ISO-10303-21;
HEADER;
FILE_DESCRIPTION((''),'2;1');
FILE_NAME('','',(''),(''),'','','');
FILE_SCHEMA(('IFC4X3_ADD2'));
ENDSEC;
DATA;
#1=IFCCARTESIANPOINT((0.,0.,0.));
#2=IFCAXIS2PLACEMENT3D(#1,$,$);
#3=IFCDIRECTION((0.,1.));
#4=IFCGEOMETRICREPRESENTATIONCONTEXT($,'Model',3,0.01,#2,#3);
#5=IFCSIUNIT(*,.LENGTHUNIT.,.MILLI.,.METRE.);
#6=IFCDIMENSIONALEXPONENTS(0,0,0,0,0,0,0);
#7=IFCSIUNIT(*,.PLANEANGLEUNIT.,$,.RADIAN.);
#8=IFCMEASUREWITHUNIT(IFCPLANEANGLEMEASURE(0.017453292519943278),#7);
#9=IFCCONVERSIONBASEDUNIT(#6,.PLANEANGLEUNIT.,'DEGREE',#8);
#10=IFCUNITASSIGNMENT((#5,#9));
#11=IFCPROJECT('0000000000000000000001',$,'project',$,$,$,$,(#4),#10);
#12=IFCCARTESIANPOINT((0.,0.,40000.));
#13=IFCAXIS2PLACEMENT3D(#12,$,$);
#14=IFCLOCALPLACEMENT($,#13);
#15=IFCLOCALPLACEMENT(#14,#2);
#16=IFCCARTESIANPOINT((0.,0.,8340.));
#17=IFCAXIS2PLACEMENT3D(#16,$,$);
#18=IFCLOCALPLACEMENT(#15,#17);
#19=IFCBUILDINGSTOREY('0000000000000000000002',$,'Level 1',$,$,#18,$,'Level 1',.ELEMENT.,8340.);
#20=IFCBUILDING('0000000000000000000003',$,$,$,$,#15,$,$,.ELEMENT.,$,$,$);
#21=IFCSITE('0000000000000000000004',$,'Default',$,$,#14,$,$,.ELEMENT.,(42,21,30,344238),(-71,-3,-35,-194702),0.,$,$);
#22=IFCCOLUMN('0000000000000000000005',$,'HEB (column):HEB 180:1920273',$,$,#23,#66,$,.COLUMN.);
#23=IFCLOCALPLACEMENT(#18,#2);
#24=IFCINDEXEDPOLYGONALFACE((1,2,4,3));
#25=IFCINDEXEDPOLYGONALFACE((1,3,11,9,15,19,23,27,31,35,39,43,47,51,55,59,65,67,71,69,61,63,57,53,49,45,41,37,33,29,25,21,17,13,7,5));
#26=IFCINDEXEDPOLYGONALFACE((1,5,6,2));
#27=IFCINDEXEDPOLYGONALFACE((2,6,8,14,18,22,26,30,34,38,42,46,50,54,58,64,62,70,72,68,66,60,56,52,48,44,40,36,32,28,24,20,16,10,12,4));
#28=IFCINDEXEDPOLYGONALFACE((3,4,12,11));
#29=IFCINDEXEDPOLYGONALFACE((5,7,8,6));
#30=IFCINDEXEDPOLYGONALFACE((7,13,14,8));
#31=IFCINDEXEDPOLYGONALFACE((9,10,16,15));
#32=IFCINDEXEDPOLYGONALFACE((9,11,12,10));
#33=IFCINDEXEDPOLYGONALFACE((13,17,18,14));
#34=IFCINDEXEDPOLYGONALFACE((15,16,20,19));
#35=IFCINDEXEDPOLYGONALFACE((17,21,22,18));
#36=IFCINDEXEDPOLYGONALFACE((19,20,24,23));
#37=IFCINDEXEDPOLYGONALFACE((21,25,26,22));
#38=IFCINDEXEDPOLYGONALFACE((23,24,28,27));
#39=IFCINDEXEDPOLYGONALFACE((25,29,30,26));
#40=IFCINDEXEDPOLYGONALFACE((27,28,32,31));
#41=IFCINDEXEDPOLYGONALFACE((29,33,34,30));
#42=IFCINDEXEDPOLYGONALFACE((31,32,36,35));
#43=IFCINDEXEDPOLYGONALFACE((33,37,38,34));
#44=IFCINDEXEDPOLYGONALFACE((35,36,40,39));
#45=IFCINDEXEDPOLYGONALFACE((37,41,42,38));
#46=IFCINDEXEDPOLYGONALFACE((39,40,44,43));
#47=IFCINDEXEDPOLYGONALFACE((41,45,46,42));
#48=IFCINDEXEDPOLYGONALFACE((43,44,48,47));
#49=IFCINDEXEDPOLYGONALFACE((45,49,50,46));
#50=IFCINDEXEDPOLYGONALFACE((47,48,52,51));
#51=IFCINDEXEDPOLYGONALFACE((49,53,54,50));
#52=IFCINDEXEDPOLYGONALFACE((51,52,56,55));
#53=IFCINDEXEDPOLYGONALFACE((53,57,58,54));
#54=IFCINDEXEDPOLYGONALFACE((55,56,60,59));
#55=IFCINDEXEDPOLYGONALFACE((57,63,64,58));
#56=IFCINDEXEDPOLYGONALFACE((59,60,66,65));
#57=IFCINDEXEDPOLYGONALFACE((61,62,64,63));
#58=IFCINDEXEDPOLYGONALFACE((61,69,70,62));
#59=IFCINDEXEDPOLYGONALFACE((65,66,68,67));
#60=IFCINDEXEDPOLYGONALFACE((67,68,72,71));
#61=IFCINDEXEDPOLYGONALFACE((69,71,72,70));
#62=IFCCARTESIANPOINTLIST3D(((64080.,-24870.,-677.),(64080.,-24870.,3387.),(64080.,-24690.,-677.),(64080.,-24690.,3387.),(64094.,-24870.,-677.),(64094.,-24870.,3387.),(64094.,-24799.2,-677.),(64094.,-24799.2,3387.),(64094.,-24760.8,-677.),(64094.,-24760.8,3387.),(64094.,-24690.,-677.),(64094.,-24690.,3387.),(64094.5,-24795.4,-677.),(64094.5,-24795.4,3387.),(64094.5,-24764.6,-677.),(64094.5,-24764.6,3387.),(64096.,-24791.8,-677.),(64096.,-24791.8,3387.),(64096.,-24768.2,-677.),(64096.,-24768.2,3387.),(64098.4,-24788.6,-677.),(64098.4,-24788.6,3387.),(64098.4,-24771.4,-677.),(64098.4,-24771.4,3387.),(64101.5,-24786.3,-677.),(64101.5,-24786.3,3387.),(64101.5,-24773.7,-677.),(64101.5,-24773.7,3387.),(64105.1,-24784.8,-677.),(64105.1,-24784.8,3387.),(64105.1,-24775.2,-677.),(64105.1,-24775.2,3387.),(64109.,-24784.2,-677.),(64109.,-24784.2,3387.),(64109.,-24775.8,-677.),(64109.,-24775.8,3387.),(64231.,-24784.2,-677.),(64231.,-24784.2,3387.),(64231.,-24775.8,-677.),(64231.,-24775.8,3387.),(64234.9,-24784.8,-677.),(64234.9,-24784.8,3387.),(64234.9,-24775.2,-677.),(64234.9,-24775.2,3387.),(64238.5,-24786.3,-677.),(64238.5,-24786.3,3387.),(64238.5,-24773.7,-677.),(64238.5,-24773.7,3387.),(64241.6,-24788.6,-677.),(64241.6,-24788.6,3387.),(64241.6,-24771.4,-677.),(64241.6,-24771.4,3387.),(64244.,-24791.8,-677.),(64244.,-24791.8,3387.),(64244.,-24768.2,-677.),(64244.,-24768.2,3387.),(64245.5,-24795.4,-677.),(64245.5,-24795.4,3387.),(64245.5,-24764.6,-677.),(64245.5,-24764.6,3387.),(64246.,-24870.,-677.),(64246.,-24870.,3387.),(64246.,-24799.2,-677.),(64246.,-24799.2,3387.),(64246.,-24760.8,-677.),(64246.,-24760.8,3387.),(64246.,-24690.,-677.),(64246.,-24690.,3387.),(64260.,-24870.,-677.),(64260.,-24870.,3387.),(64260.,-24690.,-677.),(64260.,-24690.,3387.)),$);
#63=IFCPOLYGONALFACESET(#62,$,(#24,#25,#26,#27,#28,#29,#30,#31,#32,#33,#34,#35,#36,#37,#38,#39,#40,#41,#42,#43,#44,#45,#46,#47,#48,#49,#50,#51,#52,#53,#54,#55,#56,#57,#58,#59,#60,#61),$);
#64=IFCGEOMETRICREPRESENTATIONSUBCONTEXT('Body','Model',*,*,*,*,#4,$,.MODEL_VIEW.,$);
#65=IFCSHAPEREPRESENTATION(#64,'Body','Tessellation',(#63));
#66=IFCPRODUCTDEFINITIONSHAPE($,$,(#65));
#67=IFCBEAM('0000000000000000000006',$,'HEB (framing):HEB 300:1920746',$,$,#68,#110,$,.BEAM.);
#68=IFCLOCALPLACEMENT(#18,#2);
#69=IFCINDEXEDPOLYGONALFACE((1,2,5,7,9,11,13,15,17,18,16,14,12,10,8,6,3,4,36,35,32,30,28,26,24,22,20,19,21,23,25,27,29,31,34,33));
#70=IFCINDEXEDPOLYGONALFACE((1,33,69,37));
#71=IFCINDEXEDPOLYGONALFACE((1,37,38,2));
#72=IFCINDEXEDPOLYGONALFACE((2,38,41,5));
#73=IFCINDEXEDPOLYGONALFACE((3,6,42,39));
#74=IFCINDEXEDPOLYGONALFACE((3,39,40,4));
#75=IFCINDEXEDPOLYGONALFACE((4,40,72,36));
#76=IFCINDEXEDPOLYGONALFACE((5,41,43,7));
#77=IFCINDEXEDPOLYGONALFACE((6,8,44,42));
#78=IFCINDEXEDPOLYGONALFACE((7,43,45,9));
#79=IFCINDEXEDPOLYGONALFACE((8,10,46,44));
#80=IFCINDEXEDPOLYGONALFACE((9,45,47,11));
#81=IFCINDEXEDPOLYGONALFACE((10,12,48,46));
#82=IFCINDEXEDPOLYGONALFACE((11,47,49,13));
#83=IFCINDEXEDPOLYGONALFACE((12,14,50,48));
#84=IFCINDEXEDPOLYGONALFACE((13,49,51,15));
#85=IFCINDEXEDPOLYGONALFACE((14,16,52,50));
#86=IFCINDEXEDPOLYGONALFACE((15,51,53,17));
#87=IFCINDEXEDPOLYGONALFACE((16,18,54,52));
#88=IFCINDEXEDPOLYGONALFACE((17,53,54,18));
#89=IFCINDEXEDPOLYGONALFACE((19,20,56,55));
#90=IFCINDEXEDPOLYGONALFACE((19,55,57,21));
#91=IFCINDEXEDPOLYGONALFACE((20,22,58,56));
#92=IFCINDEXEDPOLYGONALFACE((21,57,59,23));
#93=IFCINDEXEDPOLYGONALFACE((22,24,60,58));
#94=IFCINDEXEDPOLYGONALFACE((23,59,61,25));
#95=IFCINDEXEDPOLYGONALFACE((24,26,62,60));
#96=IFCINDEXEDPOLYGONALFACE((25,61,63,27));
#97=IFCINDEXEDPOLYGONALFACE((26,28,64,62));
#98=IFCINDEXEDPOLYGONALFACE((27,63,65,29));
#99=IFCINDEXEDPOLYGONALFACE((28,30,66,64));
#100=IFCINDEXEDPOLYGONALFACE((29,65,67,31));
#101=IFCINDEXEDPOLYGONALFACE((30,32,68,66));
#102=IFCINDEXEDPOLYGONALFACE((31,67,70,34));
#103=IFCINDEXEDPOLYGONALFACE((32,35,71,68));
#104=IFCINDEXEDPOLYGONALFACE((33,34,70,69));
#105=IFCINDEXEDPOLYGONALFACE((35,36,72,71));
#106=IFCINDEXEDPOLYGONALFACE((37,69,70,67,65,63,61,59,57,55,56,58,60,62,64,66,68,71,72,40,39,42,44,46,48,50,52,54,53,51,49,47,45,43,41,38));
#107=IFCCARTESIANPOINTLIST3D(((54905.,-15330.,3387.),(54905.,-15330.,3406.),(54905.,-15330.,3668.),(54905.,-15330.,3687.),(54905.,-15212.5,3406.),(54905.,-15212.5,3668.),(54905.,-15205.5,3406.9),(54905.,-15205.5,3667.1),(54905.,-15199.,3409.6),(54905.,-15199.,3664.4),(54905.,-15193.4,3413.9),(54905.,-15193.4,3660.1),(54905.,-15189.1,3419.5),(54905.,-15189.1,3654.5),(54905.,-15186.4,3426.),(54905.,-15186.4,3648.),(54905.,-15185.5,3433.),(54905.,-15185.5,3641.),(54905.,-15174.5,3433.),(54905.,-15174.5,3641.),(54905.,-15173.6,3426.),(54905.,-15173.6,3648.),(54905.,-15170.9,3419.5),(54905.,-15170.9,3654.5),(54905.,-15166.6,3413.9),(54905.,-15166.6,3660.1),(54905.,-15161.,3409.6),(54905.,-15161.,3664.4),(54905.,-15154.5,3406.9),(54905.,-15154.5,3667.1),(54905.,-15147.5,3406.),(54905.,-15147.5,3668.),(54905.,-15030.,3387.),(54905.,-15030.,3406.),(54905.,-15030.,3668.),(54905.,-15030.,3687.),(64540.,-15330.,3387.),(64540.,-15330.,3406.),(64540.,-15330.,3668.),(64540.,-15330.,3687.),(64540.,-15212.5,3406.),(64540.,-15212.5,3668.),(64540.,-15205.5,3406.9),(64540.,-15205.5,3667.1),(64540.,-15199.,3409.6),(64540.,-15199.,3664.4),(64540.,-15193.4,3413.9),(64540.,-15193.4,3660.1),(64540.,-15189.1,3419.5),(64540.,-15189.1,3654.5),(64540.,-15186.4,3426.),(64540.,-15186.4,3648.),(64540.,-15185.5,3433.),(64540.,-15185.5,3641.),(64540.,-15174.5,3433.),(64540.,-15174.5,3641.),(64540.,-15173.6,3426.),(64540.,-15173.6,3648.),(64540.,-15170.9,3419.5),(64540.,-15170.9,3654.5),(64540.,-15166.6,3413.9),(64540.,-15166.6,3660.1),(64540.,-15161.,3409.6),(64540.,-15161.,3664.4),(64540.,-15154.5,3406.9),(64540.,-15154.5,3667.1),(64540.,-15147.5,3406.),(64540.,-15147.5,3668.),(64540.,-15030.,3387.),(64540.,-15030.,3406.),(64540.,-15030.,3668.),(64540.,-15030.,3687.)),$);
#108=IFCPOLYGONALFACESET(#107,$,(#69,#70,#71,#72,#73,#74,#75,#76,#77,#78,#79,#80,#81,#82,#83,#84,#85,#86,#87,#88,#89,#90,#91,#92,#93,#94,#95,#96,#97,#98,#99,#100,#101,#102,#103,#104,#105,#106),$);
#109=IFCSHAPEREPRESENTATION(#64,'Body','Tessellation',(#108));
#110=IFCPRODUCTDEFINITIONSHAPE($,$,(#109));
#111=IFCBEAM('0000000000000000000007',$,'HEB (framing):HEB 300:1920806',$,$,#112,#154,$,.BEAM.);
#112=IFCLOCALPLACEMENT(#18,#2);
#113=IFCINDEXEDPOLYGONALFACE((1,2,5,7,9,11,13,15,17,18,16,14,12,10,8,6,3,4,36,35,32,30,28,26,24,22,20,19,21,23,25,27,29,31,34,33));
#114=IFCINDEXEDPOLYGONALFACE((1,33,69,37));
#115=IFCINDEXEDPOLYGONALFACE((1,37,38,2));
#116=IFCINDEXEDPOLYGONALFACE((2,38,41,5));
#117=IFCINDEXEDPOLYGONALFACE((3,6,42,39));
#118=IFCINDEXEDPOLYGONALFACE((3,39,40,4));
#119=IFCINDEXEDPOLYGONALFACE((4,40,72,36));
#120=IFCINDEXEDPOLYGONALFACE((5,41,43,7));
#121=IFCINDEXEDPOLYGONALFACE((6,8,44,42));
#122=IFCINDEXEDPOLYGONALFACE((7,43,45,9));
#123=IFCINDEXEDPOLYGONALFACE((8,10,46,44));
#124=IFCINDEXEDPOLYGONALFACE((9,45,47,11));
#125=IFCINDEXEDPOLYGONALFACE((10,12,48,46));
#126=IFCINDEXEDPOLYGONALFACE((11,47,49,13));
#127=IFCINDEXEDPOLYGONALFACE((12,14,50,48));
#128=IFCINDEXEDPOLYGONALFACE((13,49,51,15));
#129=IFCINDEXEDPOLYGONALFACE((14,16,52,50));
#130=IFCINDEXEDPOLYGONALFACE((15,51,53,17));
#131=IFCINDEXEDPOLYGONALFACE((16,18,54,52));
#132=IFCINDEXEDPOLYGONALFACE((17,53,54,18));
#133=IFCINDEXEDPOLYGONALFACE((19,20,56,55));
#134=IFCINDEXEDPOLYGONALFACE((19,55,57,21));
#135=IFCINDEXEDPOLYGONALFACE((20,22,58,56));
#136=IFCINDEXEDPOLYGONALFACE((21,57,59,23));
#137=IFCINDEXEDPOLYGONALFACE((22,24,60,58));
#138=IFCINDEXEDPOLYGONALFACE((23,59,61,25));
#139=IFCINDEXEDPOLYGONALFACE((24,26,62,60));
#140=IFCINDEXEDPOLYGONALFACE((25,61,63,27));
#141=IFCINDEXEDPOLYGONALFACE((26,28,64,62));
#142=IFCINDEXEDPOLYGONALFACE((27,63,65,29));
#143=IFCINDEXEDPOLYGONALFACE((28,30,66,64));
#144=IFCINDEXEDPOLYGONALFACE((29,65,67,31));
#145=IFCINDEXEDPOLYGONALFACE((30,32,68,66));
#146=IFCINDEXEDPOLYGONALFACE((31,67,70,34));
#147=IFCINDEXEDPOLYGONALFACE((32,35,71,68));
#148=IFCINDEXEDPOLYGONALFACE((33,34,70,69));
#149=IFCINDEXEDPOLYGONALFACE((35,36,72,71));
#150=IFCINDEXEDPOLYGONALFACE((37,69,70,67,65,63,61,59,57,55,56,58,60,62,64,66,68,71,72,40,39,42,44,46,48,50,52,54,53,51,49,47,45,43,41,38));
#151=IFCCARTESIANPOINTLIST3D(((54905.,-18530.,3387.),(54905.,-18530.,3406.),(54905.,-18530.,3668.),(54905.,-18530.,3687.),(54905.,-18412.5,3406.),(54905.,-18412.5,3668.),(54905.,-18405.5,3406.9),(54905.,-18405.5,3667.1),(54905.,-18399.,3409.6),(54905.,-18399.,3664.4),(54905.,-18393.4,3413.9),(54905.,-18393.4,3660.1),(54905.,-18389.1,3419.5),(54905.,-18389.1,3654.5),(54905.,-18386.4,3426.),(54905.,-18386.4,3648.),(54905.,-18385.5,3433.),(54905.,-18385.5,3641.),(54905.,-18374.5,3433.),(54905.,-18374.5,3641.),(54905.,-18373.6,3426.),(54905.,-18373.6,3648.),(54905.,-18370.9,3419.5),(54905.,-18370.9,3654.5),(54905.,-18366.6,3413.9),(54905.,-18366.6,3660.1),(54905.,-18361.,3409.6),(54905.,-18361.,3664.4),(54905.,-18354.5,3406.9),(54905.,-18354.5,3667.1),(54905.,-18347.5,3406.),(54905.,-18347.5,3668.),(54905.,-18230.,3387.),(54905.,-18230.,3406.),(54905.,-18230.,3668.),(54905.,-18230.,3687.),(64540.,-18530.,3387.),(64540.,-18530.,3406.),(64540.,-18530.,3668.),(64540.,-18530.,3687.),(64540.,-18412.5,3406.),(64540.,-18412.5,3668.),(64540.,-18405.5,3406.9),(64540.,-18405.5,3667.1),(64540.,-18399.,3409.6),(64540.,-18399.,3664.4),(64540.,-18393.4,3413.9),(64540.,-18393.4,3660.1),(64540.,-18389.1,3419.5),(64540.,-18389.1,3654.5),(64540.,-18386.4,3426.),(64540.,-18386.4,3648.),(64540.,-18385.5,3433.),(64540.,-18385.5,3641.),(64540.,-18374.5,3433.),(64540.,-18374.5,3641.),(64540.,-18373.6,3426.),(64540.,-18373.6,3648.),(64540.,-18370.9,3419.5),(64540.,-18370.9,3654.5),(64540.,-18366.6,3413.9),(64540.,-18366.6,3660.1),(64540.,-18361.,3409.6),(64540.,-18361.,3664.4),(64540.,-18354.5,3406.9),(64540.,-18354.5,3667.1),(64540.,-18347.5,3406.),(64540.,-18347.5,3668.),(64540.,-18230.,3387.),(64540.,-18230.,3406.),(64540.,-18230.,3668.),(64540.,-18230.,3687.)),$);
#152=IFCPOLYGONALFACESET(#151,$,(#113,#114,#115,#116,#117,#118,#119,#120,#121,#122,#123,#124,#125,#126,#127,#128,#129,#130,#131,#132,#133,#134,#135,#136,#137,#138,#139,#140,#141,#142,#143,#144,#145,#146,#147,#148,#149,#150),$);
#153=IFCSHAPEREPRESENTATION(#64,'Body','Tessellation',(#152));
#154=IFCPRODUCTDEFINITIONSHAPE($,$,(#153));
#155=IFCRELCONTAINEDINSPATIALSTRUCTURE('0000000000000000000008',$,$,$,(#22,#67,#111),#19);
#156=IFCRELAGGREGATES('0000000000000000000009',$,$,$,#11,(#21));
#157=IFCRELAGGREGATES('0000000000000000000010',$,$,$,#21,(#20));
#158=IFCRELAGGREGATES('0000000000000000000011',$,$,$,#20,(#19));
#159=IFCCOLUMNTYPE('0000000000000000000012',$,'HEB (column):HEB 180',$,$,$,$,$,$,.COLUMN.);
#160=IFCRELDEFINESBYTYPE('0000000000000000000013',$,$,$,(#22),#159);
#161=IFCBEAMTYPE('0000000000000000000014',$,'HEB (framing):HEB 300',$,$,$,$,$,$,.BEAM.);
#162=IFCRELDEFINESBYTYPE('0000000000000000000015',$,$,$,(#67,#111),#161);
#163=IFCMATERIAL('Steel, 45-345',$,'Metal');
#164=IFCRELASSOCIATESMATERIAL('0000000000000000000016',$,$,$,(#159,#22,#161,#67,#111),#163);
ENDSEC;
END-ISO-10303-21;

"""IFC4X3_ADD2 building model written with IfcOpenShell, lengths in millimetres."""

from ifc_helpers import new_model, entity, si_unit, converted_unit, direction, frame, frame_2d, origin, origin_2d_with_axis, place, context, subcontext, project, spatial, polyline, circle_curve, parameter, trimmed, segment, composite_curve, i_section, outline, extrude, source, transform, mapped, material, material_profile, profile_set, profile_usage, type_object, type_shapes, element, save


model = new_model("IFC4X3_ADD2")

# Units and contexts
model_context = context("Model", 3, precision=0.01, world=origin(), true_north=direction((0.0, 1.0)))
body_context = subcontext(model_context, "Body", "Model", "MODEL_VIEW")
ifc_project = project(units=[si_unit("LENGTHUNIT", "METRE", prefix="MILLI"), converted_unit("PLANEANGLEUNIT", "DEGREE", entity("IfcPlaneAngleMeasure", 0.017453292519943278), si_unit("PLANEANGLEUNIT", "RADIAN"), dimensions=[0, 0, 0, 0, 0, 0, 0])], contexts=[model_context])

# Site, building, storey
site_placement = place(None, frame((0.0, 0.0, 40000.0)))
site = spatial("IfcSite", under=ifc_project, at=site_placement, Name="Default", CompositionType="ELEMENT", RefLatitude=(42, 21, 30, 344238), RefLongitude=(-71, -3, -35, -194702), RefElevation=0.0)
building_placement = place(site_placement, origin())
building = spatial("IfcBuilding", under=site, at=building_placement, CompositionType="ELEMENT")
storey_placement = place(building_placement, frame((0.0, 0.0, 8340.0)))
storey = spatial("IfcBuildingStorey", under=building, at=storey_placement, Name="Level 1", LongName="Level 1", CompositionType="ELEMENT", Elevation=8340.0)

# Column
ifc_material_1 = material(Name="Steel, 45-345", Category="Metal")
ifc_material_profile_1 = material_profile(ifc_material_1, i_section(OverallWidth=180.0, OverallDepth=180.0, WebThickness=8.5, FlangeThickness=14.0, FilletRadius=15.0, at=origin_2d_with_axis()), Name="HEB 180")
ifc_profile_set_1 = profile_set([ifc_material_profile_1], Name="HEB 180")
ifc_profile_usage_1 = profile_usage(ifc_profile_set_1)
column_type_1 = type_object("IfcColumnType", Name="HEB (column):HEB 180", PredefinedType="COLUMN", material=ifc_profile_set_1)
shared_shape_1 = source(origin(), body_context, "Body", "SweptSolid", [
    extrude(i_section(OverallWidth=180.0, OverallDepth=180.0, WebThickness=8.5, FlangeThickness=14.0, FilletRadius=15.0, at=origin_2d_with_axis()), frame((0.0, 0.0, 7663.0), z_axis=(0.0, 0.0, 1.0), x_axis=(-1.0, 0.0, 0.0)), (0.0, 0.0, 1.0), 4064.0),
])
type_shapes(column_type_1, [shared_shape_1])
column_placement = place(storey_placement, frame((64170.0, -24780.0, -8340.0), z_axis=(0.0, 0.0, 1.0), x_axis=(0.0, -1.0, 0.0)))
element("IfcColumn", 1, at=column_placement, inside=storey, type_object=column_type_1, material=ifc_profile_usage_1, Name="HEB (column):HEB 180:1920273", PredefinedType="COLUMN", context=body_context, shape_type="MappedRepresentation", body=[
    mapped(shared_shape_1, transform((0.0, 0.0, 0.0), scale=1.0)),
])

# Beams
ifc_material_profile_2 = material_profile(ifc_material_1, outline(composite_curve([segment(polyline([(-150.0, -131.0), (-150.0, -150.0)]), True, "CONTINUOUS"), segment(polyline([(-150.0, -150.0), (150.0, -150.0)]), True, "CONTINUOUS"), segment(polyline([(150.0, -150.0), (150.0, -131.0)]), True, "CONTINUOUS"), segment(polyline([(150.0, -131.0), (32.5, -131.0)]), True, "CONTINUOUS"), segment(trimmed(circle_curve(frame_2d((32.5, -104.0), x_axis=(1.0, 0.0)), 27.0), [parameter(180.0)], [parameter(270.0)], True, "PARAMETER"), False, "CONTINUOUS"), segment(polyline([(5.5, -104.0), (5.5, 104.0)]), True, "CONTINUOUS"), segment(trimmed(circle_curve(frame_2d((32.5, 104.0), x_axis=(1.0, 0.0)), 27.0), [parameter(90.0)], [parameter(180.0)], True, "PARAMETER"), False, "CONTINUOUS"), segment(polyline([(32.5, 131.0), (150.0, 131.0)]), True, "CONTINUOUS"), segment(polyline([(150.0, 131.0), (150.0, 150.0)]), True, "CONTINUOUS"), segment(polyline([(150.0, 150.0), (-150.0, 150.0)]), True, "CONTINUOUS"), segment(polyline([(-150.0, 150.0), (-150.0, 131.0)]), True, "CONTINUOUS"), segment(polyline([(-150.0, 131.0), (-32.5, 131.0)]), True, "CONTINUOUS"), segment(trimmed(circle_curve(frame_2d((-32.5, 104.0), x_axis=(1.0, 0.0)), 27.0), [parameter(360.0)], [parameter(90.0)], True, "PARAMETER"), False, "CONTINUOUS"), segment(polyline([(-5.5, 104.0), (-5.5, -104.0)]), True, "CONTINUOUS"), segment(trimmed(circle_curve(frame_2d((-32.5, -104.0), x_axis=(1.0, 0.0)), 27.0), [parameter(270.0)], [parameter(0.0)], True, "PARAMETER"), False, "CONTINUOUS"), segment(polyline([(-32.5, -131.0), (-150.0, -131.0)]), True, "CONTINUOUS")], self_intersect=False)), Name="HEB 300")
ifc_profile_set_2 = profile_set([ifc_material_profile_2], Name="HEB 300")
ifc_profile_usage_2 = profile_usage(ifc_profile_set_2, cardinal=8)
beam_type_1 = type_object("IfcBeamType", Name="HEB (framing):HEB 300", PredefinedType="BEAM", material=ifc_profile_set_2)
shared_shape_2 = source(origin(), body_context, "Body", "SweptSolid", [
    extrude(outline(composite_curve([segment(polyline([(-150.0, -131.0), (-150.0, -150.0)]), True, "CONTINUOUS"), segment(polyline([(-150.0, -150.0), (150.0, -150.0)]), True, "CONTINUOUS"), segment(polyline([(150.0, -150.0), (150.0, -131.0)]), True, "CONTINUOUS"), segment(polyline([(150.0, -131.0), (32.5, -131.0)]), True, "CONTINUOUS"), segment(trimmed(circle_curve(frame_2d((32.5, -104.0), x_axis=(1.0, 0.0)), 27.0), [parameter(180.0)], [parameter(270.0)], True, "PARAMETER"), False, "CONTINUOUS"), segment(polyline([(5.5, -104.0), (5.5, 104.0)]), True, "CONTINUOUS"), segment(trimmed(circle_curve(frame_2d((32.5, 104.0), x_axis=(1.0, 0.0)), 27.0), [parameter(90.0)], [parameter(180.0)], True, "PARAMETER"), False, "CONTINUOUS"), segment(polyline([(32.5, 131.0), (150.0, 131.0)]), True, "CONTINUOUS"), segment(polyline([(150.0, 131.0), (150.0, 150.0)]), True, "CONTINUOUS"), segment(polyline([(150.0, 150.0), (-150.0, 150.0)]), True, "CONTINUOUS"), segment(polyline([(-150.0, 150.0), (-150.0, 131.0)]), True, "CONTINUOUS"), segment(polyline([(-150.0, 131.0), (-32.5, 131.0)]), True, "CONTINUOUS"), segment(trimmed(circle_curve(frame_2d((-32.5, 104.0), x_axis=(1.0, 0.0)), 27.0), [parameter(360.0)], [parameter(90.0)], True, "PARAMETER"), False, "CONTINUOUS"), segment(polyline([(-5.5, 104.0), (-5.5, -104.0)]), True, "CONTINUOUS"), segment(trimmed(circle_curve(frame_2d((-32.5, -104.0), x_axis=(1.0, 0.0)), 27.0), [parameter(270.0)], [parameter(0.0)], True, "PARAMETER"), False, "CONTINUOUS"), segment(polyline([(-32.5, -131.0), (-150.0, -131.0)]), True, "CONTINUOUS")], self_intersect=False)), frame((-4782.5, 0.0, 0.0), z_axis=(-1.0, 0.0, 0.0), x_axis=(0.0, -1.0, 0.0)), (0.0, 0.0, -1.0), 9635.0),
])
type_shapes(beam_type_1, [shared_shape_2])
for number, where, name in (
    (2, (59687.5, -15180.0, 3537.0), "HEB (framing):HEB 300:1920746"),
    (3, (59687.5, -18380.0, 3537.0), "HEB (framing):HEB 300:1920806"),
):
    element("IfcBeam", number, at=place(storey_placement, frame(where)), inside=storey, type_object=beam_type_1, material=ifc_profile_usage_2, Name=name, PredefinedType="BEAM", context=body_context, shape_type="MappedRepresentation", body=[
        mapped(shared_shape_2, transform((0.0, 0.0, 0.0), scale=1.0)),
    ])

save(model, "model.ifc")
